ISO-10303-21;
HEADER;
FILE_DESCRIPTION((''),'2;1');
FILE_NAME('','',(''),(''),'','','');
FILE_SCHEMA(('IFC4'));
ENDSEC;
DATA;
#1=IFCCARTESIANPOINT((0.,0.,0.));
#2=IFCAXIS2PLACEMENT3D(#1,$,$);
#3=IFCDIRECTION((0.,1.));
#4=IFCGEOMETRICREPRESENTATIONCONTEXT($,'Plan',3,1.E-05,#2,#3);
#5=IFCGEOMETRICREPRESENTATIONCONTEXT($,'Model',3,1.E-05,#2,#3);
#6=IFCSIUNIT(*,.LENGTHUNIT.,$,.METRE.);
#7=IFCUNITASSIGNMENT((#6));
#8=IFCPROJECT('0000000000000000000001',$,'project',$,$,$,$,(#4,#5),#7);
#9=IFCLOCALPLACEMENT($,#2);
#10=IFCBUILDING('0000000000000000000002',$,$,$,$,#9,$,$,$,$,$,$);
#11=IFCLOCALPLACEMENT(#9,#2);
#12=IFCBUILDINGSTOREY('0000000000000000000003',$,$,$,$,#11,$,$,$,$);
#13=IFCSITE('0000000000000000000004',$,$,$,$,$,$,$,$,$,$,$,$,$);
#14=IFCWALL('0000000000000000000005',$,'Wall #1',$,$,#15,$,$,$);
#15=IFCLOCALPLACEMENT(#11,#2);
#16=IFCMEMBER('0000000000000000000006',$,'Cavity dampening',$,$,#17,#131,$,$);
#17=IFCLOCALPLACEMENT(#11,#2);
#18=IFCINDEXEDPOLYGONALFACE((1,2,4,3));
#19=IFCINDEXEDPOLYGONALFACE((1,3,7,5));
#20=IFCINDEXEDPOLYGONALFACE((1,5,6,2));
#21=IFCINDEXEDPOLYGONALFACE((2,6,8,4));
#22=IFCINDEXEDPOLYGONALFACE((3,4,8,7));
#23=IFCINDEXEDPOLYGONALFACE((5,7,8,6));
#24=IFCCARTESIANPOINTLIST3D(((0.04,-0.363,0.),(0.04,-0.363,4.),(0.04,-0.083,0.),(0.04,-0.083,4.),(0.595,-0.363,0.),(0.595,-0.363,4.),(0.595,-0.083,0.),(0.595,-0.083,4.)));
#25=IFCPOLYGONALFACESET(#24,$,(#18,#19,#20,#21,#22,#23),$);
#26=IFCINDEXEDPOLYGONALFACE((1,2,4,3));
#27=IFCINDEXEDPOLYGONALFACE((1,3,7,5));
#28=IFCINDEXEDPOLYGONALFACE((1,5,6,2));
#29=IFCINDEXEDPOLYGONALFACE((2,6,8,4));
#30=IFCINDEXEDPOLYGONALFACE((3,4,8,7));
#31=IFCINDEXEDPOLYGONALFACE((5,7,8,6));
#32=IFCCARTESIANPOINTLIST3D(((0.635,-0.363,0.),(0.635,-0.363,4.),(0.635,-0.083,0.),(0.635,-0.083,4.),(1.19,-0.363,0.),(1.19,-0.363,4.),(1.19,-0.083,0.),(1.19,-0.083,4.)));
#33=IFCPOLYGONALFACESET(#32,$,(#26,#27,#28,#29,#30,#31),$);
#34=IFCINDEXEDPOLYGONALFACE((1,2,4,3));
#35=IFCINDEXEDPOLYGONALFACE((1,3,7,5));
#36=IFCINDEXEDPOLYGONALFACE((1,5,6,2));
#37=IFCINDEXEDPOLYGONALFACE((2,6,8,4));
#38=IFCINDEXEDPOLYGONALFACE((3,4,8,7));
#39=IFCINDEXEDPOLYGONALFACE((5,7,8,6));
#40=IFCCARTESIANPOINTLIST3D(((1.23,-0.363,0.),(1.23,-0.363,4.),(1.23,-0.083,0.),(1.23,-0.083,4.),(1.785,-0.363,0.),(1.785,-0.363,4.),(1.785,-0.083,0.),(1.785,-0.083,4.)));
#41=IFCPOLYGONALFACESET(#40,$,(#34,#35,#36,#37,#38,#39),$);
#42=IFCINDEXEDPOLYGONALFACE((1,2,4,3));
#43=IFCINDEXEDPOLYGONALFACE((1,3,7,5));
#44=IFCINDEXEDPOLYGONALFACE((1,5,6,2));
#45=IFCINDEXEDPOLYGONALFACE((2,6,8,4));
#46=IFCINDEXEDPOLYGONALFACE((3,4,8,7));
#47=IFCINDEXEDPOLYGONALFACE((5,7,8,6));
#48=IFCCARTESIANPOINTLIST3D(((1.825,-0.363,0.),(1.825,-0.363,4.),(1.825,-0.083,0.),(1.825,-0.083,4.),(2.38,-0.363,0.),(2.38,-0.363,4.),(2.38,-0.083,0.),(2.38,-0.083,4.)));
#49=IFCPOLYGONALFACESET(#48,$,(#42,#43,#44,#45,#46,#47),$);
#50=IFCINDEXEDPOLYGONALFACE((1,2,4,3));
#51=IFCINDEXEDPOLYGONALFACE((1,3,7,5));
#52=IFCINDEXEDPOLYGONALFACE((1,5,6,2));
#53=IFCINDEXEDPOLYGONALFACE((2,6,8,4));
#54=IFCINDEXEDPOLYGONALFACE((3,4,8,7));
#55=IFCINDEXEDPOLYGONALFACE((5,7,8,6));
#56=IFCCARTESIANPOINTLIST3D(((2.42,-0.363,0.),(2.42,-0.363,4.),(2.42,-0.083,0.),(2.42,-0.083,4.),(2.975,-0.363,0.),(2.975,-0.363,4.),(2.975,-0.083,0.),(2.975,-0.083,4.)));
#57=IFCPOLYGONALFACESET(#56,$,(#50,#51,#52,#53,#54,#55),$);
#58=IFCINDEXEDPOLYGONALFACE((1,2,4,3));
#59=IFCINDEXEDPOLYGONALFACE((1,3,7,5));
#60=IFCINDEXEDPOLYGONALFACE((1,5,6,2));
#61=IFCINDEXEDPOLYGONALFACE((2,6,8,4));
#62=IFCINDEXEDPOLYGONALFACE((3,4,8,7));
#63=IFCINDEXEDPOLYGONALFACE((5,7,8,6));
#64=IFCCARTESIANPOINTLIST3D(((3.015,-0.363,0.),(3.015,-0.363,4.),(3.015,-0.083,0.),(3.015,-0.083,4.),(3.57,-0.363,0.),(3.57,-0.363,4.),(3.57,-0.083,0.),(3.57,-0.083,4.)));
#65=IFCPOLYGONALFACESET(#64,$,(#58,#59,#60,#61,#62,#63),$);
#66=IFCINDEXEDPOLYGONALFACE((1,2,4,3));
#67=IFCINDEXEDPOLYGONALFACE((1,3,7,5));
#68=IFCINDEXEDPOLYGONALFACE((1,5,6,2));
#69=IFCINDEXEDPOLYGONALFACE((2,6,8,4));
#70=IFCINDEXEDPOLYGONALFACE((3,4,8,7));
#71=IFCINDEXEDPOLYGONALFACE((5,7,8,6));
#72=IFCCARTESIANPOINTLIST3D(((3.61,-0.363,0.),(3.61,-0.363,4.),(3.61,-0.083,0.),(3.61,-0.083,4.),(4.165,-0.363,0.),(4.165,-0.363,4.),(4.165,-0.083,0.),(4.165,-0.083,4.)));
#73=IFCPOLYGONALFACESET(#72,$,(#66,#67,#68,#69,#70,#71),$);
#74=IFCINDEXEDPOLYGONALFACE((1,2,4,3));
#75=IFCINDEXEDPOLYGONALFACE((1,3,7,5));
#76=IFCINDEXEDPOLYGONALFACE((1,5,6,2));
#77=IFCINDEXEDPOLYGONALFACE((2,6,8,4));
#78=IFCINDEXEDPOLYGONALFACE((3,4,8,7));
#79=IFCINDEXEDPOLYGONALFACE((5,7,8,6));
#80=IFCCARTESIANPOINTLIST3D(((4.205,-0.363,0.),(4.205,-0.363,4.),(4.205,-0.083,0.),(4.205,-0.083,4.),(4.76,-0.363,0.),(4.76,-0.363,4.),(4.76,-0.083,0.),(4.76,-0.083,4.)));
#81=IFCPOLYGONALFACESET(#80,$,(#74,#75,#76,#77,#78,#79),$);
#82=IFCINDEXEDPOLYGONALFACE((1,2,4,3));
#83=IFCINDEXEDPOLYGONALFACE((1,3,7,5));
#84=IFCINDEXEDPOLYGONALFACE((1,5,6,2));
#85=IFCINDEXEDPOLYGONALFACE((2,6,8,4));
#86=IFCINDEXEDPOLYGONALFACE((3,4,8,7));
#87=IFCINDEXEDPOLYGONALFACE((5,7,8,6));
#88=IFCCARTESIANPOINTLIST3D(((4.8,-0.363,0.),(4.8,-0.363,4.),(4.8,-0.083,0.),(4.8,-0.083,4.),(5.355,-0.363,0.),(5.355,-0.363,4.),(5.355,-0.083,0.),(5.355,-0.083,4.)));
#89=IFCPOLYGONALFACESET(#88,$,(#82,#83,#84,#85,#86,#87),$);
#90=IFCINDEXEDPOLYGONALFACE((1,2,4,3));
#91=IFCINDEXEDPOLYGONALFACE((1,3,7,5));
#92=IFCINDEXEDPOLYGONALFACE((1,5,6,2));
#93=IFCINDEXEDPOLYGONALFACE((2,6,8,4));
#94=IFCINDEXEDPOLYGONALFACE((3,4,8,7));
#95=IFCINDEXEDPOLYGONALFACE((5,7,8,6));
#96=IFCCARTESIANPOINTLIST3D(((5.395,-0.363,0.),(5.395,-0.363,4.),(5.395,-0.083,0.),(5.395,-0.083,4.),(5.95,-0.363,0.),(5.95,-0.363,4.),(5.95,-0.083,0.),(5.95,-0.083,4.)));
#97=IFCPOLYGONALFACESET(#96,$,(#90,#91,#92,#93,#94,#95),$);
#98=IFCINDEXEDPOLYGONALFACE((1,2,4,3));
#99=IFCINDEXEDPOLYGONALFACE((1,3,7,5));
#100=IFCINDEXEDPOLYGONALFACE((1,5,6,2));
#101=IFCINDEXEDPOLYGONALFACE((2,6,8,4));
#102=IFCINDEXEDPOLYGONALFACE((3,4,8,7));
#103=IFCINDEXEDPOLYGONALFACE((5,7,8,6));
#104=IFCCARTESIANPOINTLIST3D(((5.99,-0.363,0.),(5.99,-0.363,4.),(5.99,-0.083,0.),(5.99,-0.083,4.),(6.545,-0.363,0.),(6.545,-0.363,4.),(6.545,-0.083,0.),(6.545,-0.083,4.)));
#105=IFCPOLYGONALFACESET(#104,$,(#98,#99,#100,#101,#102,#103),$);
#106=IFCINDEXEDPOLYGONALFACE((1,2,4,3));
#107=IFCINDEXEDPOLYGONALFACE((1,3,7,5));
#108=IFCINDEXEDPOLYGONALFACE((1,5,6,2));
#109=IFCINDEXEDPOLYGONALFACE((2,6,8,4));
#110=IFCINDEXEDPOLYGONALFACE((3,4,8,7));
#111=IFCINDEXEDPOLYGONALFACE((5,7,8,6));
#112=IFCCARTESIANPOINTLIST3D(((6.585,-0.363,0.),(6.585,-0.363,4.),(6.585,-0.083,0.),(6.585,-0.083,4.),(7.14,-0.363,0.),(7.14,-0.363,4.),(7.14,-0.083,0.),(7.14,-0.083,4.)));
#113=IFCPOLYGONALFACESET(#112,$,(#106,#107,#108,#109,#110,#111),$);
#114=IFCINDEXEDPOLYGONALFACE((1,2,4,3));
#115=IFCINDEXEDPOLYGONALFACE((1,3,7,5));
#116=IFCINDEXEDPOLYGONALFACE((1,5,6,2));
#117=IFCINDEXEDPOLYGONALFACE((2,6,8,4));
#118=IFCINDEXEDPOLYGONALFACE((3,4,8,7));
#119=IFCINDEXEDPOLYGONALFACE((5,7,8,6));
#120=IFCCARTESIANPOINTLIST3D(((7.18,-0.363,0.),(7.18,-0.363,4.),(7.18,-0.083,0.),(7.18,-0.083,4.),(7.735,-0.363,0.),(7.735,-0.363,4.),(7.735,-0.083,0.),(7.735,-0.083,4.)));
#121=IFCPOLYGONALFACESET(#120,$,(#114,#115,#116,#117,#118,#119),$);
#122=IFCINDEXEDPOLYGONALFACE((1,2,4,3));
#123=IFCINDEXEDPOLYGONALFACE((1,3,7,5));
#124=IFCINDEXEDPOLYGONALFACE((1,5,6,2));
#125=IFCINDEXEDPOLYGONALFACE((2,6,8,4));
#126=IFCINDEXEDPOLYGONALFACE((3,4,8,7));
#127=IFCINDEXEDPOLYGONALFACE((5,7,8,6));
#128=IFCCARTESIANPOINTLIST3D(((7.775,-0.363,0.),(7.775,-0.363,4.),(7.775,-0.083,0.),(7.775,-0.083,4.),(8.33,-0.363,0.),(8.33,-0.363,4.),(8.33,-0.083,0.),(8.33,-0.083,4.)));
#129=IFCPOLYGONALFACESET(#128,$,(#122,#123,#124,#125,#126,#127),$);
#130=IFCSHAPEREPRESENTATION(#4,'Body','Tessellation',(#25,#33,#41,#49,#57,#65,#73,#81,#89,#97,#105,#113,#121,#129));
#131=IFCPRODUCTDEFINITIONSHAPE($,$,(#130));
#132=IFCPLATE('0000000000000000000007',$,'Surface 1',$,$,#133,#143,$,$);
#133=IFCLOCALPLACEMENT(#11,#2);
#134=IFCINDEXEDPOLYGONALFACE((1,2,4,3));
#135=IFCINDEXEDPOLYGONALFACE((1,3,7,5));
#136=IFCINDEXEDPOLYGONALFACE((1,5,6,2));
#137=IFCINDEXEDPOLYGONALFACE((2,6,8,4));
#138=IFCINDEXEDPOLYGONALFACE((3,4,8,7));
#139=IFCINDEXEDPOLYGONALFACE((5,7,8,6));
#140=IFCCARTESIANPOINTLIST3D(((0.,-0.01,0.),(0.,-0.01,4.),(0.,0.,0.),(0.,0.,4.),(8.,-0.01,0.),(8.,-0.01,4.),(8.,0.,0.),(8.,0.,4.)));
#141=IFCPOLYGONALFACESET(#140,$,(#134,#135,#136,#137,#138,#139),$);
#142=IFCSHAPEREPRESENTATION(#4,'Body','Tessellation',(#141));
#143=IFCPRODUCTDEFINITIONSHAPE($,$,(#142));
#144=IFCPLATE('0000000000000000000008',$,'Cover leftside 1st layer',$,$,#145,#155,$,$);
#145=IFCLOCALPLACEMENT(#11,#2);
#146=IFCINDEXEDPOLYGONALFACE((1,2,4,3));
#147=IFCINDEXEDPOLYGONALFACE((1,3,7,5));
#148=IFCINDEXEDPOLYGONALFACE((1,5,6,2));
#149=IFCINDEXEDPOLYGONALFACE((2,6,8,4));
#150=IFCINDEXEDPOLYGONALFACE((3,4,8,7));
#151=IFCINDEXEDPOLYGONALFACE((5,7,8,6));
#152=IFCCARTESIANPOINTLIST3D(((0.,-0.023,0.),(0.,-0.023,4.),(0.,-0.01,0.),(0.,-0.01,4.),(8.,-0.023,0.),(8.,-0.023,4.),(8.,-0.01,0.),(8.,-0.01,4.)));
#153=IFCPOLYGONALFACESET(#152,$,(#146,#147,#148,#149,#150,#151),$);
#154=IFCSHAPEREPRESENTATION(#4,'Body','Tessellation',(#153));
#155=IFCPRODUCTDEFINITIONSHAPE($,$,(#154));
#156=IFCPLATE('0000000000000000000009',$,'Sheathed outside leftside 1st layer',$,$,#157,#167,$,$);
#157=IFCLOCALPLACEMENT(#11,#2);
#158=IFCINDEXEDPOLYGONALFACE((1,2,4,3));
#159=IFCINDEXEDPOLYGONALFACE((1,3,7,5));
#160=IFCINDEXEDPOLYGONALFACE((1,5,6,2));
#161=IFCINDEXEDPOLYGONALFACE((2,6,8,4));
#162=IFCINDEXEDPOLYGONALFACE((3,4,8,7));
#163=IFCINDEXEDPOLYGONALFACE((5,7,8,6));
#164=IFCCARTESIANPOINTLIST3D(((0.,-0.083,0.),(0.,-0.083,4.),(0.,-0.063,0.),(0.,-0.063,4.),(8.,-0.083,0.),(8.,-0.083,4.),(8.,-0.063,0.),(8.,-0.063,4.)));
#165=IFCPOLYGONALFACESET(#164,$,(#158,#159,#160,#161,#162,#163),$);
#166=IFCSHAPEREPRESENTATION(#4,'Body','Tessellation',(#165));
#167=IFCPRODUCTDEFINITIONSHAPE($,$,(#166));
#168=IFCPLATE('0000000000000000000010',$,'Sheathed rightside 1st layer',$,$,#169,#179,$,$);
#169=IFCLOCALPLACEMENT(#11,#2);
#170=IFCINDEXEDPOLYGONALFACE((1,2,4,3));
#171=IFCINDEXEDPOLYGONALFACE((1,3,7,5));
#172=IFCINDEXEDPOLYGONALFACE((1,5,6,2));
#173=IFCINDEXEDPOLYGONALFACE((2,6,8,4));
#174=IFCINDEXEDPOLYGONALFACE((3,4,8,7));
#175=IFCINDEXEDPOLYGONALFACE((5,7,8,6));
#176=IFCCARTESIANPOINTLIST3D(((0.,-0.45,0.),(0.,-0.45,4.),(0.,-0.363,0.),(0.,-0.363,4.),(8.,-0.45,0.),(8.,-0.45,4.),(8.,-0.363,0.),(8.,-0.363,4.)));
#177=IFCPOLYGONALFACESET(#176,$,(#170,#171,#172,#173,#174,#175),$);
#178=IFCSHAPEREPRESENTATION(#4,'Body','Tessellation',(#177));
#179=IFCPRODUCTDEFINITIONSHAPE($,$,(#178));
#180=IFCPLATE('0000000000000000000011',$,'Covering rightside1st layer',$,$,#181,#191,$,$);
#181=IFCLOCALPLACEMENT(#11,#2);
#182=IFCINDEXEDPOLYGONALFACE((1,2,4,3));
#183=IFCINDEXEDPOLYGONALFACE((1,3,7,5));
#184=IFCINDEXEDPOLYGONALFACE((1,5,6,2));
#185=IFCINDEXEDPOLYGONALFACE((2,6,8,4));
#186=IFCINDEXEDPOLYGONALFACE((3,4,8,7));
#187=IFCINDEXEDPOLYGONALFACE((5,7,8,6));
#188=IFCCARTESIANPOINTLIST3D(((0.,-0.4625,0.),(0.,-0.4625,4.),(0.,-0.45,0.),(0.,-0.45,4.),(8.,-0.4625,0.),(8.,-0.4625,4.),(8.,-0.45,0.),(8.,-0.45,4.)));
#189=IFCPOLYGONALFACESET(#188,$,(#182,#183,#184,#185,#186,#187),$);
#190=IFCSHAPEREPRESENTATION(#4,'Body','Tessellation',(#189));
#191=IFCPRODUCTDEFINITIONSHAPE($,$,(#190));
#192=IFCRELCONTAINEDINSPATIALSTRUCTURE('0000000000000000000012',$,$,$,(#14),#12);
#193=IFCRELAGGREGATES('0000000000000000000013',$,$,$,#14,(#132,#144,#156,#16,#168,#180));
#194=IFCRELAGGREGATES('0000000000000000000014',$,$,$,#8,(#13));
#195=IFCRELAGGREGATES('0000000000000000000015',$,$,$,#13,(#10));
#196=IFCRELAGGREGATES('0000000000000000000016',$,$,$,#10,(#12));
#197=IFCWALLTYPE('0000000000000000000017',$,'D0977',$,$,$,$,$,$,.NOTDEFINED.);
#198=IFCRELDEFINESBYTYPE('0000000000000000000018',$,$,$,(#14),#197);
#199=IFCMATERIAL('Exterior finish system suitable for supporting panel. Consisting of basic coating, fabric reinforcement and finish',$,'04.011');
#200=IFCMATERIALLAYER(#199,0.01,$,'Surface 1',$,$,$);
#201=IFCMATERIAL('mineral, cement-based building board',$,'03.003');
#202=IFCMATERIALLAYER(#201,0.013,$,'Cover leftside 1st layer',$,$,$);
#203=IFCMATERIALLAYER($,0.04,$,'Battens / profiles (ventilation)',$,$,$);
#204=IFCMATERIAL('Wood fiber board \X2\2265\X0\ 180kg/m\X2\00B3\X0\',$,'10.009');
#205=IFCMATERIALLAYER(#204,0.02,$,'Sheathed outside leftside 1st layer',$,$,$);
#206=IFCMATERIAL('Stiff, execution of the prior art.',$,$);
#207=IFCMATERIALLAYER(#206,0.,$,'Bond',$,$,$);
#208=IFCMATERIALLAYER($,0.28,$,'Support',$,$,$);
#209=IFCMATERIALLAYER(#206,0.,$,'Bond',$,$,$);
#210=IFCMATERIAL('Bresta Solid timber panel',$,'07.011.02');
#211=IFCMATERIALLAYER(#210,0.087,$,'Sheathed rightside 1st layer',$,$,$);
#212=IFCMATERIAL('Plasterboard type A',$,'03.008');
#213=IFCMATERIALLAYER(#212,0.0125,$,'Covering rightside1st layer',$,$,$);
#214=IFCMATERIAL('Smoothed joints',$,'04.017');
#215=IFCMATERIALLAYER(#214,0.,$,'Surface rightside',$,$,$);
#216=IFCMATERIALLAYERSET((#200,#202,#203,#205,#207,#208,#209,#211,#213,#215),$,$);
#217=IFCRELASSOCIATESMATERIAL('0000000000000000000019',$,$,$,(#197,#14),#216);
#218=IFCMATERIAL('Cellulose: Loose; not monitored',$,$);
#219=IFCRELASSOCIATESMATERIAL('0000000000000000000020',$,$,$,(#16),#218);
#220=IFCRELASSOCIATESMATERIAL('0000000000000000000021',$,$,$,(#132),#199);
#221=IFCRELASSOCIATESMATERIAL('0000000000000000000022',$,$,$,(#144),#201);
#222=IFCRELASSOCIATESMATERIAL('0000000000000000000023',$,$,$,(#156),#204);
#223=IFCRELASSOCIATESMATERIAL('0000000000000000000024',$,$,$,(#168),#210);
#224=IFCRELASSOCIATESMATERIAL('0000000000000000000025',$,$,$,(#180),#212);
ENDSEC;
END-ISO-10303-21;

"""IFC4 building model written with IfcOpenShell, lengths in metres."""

from ifc_helpers import new_model, si_unit, direction, frame, frame_2d, origin, origin_with_axes, place, context, project, spatial, rectangle, extrude, material, layer, layer_set, type_object, element, aggregate, save


model = new_model("IFC4")

# Units and contexts
plan_context = context("Plan", 3, precision=1e-05, world=origin(), true_north=direction((0.0, 1.0)))
model_context = context("Model", 3, precision=1e-05, world=origin(), true_north=direction((0.0, 1.0)))
ifc_project = project(units=[si_unit("LENGTHUNIT", "METRE")], contexts=[plan_context, model_context])

# Site, building, storey
site = spatial("IfcSite", under=ifc_project)
building_placement = place(None, origin())
building = spatial("IfcBuilding", under=site, at=building_placement)
storey_placement = place(building_placement, origin())
storey = spatial("IfcBuildingStorey", under=building, at=storey_placement)

# Wall, member, plates
ifc_material_1 = material(Name="Exterior finish system suitable for supporting panel. Consisting of basic coating, fabric reinforcement and finish", Category="04.011")
ifc_layer_1 = layer(ifc_material_1, 0.01, Name="Surface 1")
ifc_material_2 = material(Name="mineral, cement-based building board", Category="03.003")
ifc_layer_2 = layer(ifc_material_2, 0.013, Name="Cover leftside 1st layer")
ifc_layer_3 = layer(None, 0.04, Name="Battens / profiles (ventilation)")
ifc_material_3 = material(Name="Wood fiber board ≥ 180kg/m³", Category="10.009")
ifc_layer_4 = layer(ifc_material_3, 0.02, Name="Sheathed outside leftside 1st layer")
ifc_material_4 = material(Name="Stiff, execution of the prior art.")
ifc_layer_5 = layer(ifc_material_4, 0.0, Name="Bond")
ifc_layer_6 = layer(None, 0.28, Name="Support")
ifc_layer_7 = layer(ifc_material_4, 0.0, Name="Bond")
ifc_material_5 = material(Name="Bresta Solid timber panel", Category="07.011.02")
ifc_layer_8 = layer(ifc_material_5, 0.087, Name="Sheathed rightside 1st layer")
ifc_material_6 = material(Name="Plasterboard type A", Category="03.008")
ifc_layer_9 = layer(ifc_material_6, 0.0125, Name="Covering rightside1st layer")
ifc_material_7 = material(Name="Smoothed joints", Category="04.017")
ifc_layer_10 = layer(ifc_material_7, 0.0, Name="Surface rightside")
ifc_layer_set = layer_set([ifc_layer_1, ifc_layer_2, ifc_layer_3, ifc_layer_4, ifc_layer_5, ifc_layer_6, ifc_layer_7, ifc_layer_8, ifc_layer_9, ifc_layer_10])
wall_type = type_object("IfcWallType", Name="D0977", PredefinedType="NOTDEFINED", material=ifc_layer_set)
wall_placement = place(None, frame((0.0, 0.0, 0.0), z_axis=(0.0, -1.0, 0.0), x_axis=(1.0, 0.0, 0.0)))
wall = element("IfcWall", 1, at=wall_placement, inside=storey, type_object=wall_type, material=ifc_layer_set, Name="Wall #1")
ifc_material_8 = material(Name="Cellulose: Loose; not monitored")
member_1_placement = place(wall_placement, origin())
member_1 = element("IfcMember", 2, at=member_1_placement, material=ifc_material_8, Name="Cavity dampening", context=plan_context, shape_type="SweptSolid", body=[
    extrude(rectangle(XDim=0.555, YDim=0.28, at=frame_2d((0.2775, 0.14), x_axis=(1.0, 0.0))), frame((0.04, 4.0, 0.083), z_axis=(0.0, -1.0, 0.0), x_axis=(1.0, 0.0, 0.0)), (0.0, 0.0, 1.0), 4.0),
    extrude(rectangle(XDim=0.555, YDim=0.28, at=frame_2d((0.2775, 0.14), x_axis=(1.0, 0.0))), frame((0.635, 4.0, 0.083), z_axis=(0.0, -1.0, 0.0), x_axis=(1.0, 0.0, 0.0)), (0.0, 0.0, 1.0), 4.0),
    extrude(rectangle(XDim=0.555, YDim=0.28, at=frame_2d((0.2775, 0.14), x_axis=(1.0, 0.0))), frame((1.23, 4.0, 0.083), z_axis=(0.0, -1.0, 0.0), x_axis=(1.0, 0.0, 0.0)), (0.0, 0.0, 1.0), 4.0),
    extrude(rectangle(XDim=0.555, YDim=0.28, at=frame_2d((0.2775, 0.14), x_axis=(1.0, 0.0))), frame((1.825, 4.0, 0.083), z_axis=(0.0, -1.0, 0.0), x_axis=(1.0, 0.0, 0.0)), (0.0, 0.0, 1.0), 4.0),
    extrude(rectangle(XDim=0.555, YDim=0.28, at=frame_2d((0.2775, 0.14), x_axis=(1.0, 0.0))), frame((2.42, 4.0, 0.083), z_axis=(0.0, -1.0, 0.0), x_axis=(1.0, 0.0, 0.0)), (0.0, 0.0, 1.0), 4.0),
    extrude(rectangle(XDim=0.555, YDim=0.28, at=frame_2d((0.2775, 0.14), x_axis=(1.0, 0.0))), frame((3.015, 4.0, 0.083), z_axis=(0.0, -1.0, 0.0), x_axis=(1.0, 0.0, 0.0)), (0.0, 0.0, 1.0), 4.0),
    extrude(rectangle(XDim=0.555, YDim=0.28, at=frame_2d((0.2775, 0.14), x_axis=(1.0, 0.0))), frame((3.61, 4.0, 0.083), z_axis=(0.0, -1.0, 0.0), x_axis=(1.0, 0.0, 0.0)), (0.0, 0.0, 1.0), 4.0),
    extrude(rectangle(XDim=0.555, YDim=0.28, at=frame_2d((0.2775, 0.14), x_axis=(1.0, 0.0))), frame((4.205, 4.0, 0.083), z_axis=(0.0, -1.0, 0.0), x_axis=(1.0, 0.0, 0.0)), (0.0, 0.0, 1.0), 4.0),
    extrude(rectangle(XDim=0.555, YDim=0.28, at=frame_2d((0.2775, 0.14), x_axis=(1.0, 0.0))), frame((4.8, 4.0, 0.083), z_axis=(0.0, -1.0, 0.0), x_axis=(1.0, 0.0, 0.0)), (0.0, 0.0, 1.0), 4.0),
    extrude(rectangle(XDim=0.555, YDim=0.28, at=frame_2d((0.2775, 0.14), x_axis=(1.0, 0.0))), frame((5.395, 4.0, 0.083), z_axis=(0.0, -1.0, 0.0), x_axis=(1.0, 0.0, 0.0)), (0.0, 0.0, 1.0), 4.0),
    extrude(rectangle(XDim=0.555, YDim=0.28, at=frame_2d((0.2775, 0.14), x_axis=(1.0, 0.0))), frame((5.99, 4.0, 0.083), z_axis=(0.0, -1.0, 0.0), x_axis=(1.0, 0.0, 0.0)), (0.0, 0.0, 1.0), 4.0),
    extrude(rectangle(XDim=0.555, YDim=0.28, at=frame_2d((0.2775, 0.14), x_axis=(1.0, 0.0))), frame((6.585, 4.0, 0.083), z_axis=(0.0, -1.0, 0.0), x_axis=(1.0, 0.0, 0.0)), (0.0, 0.0, 1.0), 4.0),
    extrude(rectangle(XDim=0.555, YDim=0.28, at=frame_2d((0.2775, 0.14), x_axis=(1.0, 0.0))), frame((7.18, 4.0, 0.083), z_axis=(0.0, -1.0, 0.0), x_axis=(1.0, 0.0, 0.0)), (0.0, 0.0, 1.0), 4.0),
    extrude(rectangle(XDim=0.555, YDim=0.28, at=frame_2d((0.2775, 0.14), x_axis=(1.0, 0.0))), frame((7.775, 4.0, 0.083), z_axis=(0.0, -1.0, 0.0), x_axis=(1.0, 0.0, 0.0)), (0.0, 0.0, 1.0), 4.0),
])
plate_1_placement = place(wall_placement, origin())
plate_1 = element("IfcPlate", 3, at=plate_1_placement, material=ifc_material_1, Name="Surface 1", context=plan_context, shape_type="SweptSolid", body=[
    extrude(rectangle(XDim=8.0, YDim=4.0, at=frame_2d((4.0, 2.0), x_axis=(1.0, 0.0))), origin_with_axes(), (0.0, 0.0, 1.0), 0.01),
])
plate_2_placement = place(wall_placement, origin())
plate_2 = element("IfcPlate", 4, at=plate_2_placement, material=ifc_material_2, Name="Cover leftside 1st layer", context=plan_context, shape_type="SweptSolid", body=[
    extrude(rectangle(XDim=8.0, YDim=4.0, at=frame_2d((4.0, 2.0), x_axis=(1.0, 0.0))), frame((0.0, 0.0, 0.01), z_axis=(0.0, 0.0, 1.0), x_axis=(1.0, 0.0, 0.0)), (0.0, 0.0, 1.0), 0.013),
])
plate_3_placement = place(wall_placement, origin())
plate_3 = element("IfcPlate", 5, at=plate_3_placement, material=ifc_material_3, Name="Sheathed outside leftside 1st layer", context=plan_context, shape_type="SweptSolid", body=[
    extrude(rectangle(XDim=8.0, YDim=4.0, at=frame_2d((4.0, 2.0), x_axis=(1.0, 0.0))), frame((0.0, 0.0, 0.063), z_axis=(0.0, 0.0, 1.0), x_axis=(1.0, 0.0, 0.0)), (0.0, 0.0, 1.0), 0.02),
])
plate_4_placement = place(wall_placement, origin())
plate_4 = element("IfcPlate", 6, at=plate_4_placement, material=ifc_material_5, Name="Sheathed rightside 1st layer", context=plan_context, shape_type="SweptSolid", body=[
    extrude(rectangle(XDim=8.0, YDim=4.0, at=frame_2d((4.0, 2.0), x_axis=(1.0, 0.0))), frame((0.0, 0.0, 0.363), z_axis=(0.0, 0.0, 1.0), x_axis=(1.0, 0.0, 0.0)), (0.0, 0.0, 1.0), 0.087),
])
plate_5_placement = place(wall_placement, origin())
plate_5 = element("IfcPlate", 7, at=plate_5_placement, material=ifc_material_6, Name="Covering rightside1st layer", context=plan_context, shape_type="SweptSolid", body=[
    extrude(rectangle(XDim=8.0, YDim=4.0, at=frame_2d((4.0, 2.0), x_axis=(1.0, 0.0))), frame((0.0, 0.0, 0.45), z_axis=(0.0, 0.0, 1.0), x_axis=(1.0, 0.0, 0.0)), (0.0, 0.0, 1.0), 0.0125),
])
aggregate(wall, [plate_1, plate_2, plate_3, member_1, plate_4, plate_5])

save(model, "model.ifc")
